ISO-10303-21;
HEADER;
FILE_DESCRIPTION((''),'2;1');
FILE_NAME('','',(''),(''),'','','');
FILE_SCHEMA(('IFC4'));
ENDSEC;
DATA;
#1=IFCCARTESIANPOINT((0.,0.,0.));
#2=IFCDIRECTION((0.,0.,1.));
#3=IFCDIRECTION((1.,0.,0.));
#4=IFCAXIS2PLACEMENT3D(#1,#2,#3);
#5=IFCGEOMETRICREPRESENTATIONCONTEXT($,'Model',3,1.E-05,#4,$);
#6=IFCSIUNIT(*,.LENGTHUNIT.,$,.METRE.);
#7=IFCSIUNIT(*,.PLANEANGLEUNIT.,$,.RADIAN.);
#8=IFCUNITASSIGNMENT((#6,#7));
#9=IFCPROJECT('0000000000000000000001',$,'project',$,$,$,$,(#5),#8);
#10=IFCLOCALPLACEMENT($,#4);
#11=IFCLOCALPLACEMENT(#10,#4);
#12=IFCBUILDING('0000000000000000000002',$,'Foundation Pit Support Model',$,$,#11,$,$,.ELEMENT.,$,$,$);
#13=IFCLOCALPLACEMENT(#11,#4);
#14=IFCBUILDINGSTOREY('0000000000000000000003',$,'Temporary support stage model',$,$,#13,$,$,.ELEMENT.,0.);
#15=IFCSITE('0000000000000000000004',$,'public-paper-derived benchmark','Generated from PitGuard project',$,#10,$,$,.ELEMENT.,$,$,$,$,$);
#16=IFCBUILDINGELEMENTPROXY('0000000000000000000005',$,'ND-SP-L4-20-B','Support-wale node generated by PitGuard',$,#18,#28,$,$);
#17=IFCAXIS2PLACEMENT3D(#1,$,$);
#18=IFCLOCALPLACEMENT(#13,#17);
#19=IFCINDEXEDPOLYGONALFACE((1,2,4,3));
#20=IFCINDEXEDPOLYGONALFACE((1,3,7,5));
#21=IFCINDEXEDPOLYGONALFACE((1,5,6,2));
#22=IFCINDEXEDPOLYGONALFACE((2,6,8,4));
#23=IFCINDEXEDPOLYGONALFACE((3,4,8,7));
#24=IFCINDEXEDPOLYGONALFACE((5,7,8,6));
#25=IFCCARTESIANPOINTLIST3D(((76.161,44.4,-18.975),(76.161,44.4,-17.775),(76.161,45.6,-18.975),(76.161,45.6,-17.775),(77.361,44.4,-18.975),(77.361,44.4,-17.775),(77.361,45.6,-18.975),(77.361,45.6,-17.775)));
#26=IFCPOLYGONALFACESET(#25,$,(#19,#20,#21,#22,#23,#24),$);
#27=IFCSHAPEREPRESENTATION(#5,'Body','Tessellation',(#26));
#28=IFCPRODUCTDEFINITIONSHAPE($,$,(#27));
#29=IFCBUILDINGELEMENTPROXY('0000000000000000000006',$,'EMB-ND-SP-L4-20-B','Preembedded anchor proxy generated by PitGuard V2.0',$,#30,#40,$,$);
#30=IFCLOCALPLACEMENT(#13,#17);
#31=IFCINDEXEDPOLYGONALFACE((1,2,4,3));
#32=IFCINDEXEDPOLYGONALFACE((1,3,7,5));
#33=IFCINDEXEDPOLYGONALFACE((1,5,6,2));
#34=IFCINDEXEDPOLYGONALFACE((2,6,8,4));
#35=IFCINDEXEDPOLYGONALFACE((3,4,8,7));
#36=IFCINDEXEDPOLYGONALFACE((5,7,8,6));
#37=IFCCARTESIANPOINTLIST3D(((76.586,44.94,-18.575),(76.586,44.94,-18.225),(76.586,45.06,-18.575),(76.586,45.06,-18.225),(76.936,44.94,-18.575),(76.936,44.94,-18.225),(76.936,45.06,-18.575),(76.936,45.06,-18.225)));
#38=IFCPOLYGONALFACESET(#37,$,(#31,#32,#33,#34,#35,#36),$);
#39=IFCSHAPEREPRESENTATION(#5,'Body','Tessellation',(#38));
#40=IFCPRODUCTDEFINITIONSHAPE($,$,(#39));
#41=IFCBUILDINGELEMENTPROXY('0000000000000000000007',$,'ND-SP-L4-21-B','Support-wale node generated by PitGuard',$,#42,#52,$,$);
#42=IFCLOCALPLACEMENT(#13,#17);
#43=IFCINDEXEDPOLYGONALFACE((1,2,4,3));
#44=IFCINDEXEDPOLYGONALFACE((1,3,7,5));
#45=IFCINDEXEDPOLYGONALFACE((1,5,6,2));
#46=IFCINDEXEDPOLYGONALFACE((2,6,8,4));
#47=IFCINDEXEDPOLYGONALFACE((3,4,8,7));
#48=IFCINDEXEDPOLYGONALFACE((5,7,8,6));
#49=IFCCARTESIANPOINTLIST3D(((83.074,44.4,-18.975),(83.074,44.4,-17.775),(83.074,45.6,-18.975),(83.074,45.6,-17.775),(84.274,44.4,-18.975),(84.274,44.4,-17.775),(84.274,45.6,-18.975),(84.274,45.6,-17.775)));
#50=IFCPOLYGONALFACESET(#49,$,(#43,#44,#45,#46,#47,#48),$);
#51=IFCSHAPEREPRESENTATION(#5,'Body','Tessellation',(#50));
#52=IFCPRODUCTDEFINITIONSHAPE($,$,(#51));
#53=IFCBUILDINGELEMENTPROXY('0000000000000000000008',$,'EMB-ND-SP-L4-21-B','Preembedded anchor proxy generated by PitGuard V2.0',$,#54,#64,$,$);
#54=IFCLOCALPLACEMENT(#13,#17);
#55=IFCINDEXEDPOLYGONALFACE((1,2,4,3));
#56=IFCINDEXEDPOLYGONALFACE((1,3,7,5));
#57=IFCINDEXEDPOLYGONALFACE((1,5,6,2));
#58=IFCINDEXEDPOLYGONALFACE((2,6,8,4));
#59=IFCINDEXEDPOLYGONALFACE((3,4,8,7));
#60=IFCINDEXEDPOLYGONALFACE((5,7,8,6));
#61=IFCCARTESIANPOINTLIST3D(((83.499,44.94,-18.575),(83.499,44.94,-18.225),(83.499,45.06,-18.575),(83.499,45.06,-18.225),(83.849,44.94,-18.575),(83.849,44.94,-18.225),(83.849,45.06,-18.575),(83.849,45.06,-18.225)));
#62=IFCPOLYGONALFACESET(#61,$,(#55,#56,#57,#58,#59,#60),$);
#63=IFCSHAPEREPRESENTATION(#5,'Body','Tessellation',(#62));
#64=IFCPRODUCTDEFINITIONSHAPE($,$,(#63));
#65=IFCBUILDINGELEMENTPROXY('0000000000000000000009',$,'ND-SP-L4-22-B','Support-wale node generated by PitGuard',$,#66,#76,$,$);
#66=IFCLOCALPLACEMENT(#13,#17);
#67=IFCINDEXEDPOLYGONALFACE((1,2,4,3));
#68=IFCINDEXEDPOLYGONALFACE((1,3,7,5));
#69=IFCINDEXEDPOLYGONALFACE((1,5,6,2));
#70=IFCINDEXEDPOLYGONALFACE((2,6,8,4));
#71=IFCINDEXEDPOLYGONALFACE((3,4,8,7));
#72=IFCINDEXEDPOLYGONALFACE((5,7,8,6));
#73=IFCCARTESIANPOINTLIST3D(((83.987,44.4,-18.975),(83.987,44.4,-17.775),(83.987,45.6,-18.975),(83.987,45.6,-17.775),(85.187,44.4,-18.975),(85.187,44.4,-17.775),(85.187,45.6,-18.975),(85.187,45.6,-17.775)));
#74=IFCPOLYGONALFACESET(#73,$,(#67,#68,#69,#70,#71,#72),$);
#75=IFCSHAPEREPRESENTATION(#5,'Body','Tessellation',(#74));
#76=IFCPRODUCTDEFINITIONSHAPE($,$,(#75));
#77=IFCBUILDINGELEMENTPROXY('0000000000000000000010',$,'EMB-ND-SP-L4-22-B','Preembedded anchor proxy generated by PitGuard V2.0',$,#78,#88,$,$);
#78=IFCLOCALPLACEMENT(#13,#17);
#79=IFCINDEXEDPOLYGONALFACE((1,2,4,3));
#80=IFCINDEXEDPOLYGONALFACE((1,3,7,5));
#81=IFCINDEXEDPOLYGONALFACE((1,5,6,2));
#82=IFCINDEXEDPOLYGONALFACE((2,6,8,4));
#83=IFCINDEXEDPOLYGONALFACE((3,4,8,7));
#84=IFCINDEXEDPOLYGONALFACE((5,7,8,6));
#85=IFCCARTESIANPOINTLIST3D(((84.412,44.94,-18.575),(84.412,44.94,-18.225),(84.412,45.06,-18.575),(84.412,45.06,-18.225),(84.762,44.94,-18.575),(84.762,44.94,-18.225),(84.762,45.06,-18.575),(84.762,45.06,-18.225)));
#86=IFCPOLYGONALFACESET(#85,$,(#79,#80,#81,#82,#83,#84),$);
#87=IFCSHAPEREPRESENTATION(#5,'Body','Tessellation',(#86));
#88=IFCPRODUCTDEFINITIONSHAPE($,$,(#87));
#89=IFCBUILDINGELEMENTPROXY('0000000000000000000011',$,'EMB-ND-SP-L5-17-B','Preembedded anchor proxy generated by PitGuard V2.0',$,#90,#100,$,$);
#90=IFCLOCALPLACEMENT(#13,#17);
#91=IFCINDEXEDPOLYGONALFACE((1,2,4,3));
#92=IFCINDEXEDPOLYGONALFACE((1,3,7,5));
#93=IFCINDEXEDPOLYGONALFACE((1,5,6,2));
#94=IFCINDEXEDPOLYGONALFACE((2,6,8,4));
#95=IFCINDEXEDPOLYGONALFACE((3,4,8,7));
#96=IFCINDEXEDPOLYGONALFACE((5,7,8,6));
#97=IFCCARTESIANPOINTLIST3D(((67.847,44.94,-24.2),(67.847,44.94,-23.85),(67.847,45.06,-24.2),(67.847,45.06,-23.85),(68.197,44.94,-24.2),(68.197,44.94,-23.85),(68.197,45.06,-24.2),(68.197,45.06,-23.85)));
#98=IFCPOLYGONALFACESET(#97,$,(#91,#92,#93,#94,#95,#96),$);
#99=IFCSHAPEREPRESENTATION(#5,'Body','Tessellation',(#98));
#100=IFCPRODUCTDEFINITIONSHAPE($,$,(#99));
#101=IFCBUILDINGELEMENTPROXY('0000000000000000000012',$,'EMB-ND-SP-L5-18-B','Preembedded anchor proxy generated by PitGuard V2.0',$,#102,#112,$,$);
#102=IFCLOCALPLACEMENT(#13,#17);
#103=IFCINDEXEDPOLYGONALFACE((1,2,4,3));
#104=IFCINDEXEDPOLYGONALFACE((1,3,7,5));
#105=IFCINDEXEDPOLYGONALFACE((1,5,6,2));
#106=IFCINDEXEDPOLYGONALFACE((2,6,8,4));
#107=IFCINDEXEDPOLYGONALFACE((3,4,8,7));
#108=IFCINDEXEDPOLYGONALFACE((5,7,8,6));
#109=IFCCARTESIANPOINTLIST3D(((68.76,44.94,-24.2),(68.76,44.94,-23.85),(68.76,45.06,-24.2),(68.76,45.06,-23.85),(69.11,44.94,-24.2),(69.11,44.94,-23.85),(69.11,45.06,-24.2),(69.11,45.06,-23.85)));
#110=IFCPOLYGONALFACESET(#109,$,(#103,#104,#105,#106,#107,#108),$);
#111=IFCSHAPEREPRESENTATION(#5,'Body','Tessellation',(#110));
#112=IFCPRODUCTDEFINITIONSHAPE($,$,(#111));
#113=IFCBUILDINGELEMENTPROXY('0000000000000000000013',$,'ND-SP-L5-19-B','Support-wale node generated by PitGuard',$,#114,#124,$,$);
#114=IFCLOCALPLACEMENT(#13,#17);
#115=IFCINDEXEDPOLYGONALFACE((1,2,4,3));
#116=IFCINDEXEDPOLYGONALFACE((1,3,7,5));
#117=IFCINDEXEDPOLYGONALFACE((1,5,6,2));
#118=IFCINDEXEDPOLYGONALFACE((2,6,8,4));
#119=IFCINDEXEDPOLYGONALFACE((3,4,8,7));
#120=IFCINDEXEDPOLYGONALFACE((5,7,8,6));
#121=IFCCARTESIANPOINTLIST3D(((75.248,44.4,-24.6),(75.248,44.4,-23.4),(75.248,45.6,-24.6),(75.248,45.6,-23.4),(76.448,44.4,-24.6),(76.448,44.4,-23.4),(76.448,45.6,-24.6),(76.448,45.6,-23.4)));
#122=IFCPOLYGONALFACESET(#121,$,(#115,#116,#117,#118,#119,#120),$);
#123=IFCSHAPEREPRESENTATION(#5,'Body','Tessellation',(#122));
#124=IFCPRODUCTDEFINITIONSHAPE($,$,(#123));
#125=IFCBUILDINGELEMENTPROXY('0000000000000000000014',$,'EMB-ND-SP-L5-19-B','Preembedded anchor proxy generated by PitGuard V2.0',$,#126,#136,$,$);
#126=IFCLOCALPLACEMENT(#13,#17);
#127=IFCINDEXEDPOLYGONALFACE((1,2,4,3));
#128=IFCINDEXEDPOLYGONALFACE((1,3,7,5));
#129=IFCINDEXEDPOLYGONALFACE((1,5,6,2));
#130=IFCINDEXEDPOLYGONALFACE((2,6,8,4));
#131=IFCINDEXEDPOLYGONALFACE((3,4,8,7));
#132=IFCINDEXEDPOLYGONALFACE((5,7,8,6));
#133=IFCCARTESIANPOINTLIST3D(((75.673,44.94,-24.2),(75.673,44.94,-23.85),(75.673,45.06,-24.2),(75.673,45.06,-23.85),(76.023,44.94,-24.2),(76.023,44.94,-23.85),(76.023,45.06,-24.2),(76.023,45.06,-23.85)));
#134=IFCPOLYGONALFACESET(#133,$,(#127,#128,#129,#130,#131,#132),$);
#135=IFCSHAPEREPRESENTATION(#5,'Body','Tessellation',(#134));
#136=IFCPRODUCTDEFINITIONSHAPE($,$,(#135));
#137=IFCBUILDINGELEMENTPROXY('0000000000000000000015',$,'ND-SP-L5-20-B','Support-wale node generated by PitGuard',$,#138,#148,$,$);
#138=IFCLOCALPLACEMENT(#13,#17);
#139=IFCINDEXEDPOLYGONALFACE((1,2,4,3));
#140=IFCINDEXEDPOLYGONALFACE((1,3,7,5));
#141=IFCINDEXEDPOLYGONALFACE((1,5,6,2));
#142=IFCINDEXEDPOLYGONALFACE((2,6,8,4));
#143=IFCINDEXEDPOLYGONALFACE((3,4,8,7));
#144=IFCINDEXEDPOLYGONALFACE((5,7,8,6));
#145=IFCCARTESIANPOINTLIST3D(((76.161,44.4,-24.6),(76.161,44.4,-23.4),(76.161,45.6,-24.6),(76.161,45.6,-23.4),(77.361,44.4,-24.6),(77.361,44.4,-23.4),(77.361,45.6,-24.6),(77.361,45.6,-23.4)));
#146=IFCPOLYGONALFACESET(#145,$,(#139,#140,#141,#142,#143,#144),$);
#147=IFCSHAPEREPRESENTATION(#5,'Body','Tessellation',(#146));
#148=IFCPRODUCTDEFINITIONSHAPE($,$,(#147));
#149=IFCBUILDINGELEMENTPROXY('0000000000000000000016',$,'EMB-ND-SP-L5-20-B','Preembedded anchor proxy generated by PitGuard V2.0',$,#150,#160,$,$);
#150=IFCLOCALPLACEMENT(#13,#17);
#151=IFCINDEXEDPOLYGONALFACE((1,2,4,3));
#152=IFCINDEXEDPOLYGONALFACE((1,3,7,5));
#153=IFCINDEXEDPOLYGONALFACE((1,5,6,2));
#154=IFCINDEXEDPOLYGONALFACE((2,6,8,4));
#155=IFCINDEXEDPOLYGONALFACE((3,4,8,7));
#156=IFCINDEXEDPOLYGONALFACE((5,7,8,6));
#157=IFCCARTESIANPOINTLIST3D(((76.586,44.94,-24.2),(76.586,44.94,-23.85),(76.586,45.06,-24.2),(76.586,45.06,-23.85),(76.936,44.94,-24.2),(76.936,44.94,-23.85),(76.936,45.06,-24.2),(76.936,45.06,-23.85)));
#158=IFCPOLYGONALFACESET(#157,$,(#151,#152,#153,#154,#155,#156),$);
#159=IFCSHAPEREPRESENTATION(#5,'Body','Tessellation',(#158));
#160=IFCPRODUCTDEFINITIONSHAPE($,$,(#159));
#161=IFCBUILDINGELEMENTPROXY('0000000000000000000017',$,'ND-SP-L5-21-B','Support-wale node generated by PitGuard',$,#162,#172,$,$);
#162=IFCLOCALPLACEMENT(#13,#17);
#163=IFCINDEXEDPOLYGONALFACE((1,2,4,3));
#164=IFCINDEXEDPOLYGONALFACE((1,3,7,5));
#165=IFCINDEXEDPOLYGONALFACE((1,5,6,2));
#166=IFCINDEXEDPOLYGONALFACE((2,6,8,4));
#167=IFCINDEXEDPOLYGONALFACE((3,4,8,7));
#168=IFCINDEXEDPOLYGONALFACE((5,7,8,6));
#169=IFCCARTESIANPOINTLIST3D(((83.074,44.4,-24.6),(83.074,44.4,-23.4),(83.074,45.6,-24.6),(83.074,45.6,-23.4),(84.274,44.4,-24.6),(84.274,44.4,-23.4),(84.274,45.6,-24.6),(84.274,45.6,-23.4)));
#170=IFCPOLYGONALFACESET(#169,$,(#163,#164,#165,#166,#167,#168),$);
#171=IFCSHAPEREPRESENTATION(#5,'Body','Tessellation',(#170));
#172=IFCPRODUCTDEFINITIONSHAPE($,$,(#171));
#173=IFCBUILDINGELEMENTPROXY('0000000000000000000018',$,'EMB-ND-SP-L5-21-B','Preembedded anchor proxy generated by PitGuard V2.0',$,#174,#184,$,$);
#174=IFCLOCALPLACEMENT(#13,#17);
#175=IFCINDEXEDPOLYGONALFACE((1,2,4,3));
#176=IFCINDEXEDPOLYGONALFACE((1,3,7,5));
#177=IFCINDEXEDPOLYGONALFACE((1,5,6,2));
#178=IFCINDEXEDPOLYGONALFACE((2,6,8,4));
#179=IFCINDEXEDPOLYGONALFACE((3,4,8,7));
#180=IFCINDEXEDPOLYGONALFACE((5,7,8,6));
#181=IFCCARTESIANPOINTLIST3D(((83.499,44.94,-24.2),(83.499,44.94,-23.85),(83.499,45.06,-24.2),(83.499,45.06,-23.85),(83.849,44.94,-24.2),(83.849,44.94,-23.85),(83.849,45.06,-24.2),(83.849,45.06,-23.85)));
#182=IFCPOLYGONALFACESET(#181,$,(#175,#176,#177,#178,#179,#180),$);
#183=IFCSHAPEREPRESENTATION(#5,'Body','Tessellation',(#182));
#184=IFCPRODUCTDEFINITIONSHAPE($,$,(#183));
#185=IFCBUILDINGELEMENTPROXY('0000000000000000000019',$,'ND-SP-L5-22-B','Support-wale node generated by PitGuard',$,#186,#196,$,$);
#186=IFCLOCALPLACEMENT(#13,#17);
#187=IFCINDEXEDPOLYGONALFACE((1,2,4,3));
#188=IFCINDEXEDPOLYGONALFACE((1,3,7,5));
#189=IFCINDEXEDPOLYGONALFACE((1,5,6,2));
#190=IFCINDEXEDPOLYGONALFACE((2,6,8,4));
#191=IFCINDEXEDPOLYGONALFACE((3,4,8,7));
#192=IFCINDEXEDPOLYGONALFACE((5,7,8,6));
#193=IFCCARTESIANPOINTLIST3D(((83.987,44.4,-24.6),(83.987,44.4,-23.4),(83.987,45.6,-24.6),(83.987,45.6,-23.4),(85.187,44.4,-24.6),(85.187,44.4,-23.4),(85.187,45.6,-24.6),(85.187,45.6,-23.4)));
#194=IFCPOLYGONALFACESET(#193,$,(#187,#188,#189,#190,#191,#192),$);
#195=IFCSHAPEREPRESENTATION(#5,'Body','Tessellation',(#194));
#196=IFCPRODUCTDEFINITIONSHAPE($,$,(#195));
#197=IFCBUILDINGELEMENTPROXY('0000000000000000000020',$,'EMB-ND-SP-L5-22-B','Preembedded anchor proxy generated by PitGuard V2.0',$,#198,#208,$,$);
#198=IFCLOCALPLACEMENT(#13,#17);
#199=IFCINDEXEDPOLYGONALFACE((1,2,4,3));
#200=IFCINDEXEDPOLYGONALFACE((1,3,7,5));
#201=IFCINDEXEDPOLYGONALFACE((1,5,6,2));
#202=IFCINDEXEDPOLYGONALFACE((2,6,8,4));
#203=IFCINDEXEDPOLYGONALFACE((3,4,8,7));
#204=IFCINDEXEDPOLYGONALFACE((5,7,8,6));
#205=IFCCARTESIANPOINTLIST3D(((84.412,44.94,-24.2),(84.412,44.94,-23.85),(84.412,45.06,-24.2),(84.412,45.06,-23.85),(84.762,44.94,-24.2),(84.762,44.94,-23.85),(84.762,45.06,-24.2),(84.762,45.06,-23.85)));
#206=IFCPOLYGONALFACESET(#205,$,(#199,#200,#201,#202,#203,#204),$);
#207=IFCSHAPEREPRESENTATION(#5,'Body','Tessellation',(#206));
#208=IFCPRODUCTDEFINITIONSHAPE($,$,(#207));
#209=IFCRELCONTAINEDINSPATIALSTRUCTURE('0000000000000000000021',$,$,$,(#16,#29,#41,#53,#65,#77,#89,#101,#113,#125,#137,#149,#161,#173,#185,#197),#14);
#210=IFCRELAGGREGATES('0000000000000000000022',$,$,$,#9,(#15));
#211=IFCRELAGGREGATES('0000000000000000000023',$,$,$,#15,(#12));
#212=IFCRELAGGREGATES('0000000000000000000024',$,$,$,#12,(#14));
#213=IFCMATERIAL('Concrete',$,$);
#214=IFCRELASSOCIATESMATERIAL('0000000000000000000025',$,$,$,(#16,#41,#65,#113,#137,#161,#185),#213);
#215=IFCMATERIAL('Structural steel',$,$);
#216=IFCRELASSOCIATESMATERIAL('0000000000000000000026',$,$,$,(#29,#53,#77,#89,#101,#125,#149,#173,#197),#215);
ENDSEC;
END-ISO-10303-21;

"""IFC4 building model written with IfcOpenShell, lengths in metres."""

from ifc_helpers import new_model, si_unit, frame, origin_with_axes, origin_2d, place, context, project, spatial, rectangle, extrude, material, element, save


model = new_model("IFC4")

# Units and contexts
model_context = context("Model", 3, precision=1e-05, world=origin_with_axes())
ifc_project = project(units=[si_unit("LENGTHUNIT", "METRE"), si_unit("PLANEANGLEUNIT", "RADIAN")], contexts=[model_context])

# Site, building, storey
site_placement = place(None, origin_with_axes())
site = spatial("IfcSite", under=ifc_project, at=site_placement, Name="public-paper-derived benchmark", Description="Generated from PitGuard project", CompositionType="ELEMENT")
building_placement = place(site_placement, origin_with_axes())
building = spatial("IfcBuilding", under=site, at=building_placement, Name="Foundation Pit Support Model", CompositionType="ELEMENT")
storey_placement = place(building_placement, origin_with_axes())
storey = spatial("IfcBuildingStorey", under=building, at=storey_placement, Name="Temporary support stage model", CompositionType="ELEMENT", Elevation=0.0)

# Shared definitions
ifc_material_1 = material(Name="Structural steel")

# Building element proxies
ifc_material_2 = material(Name="Concrete")
proxy_1_placement = place(storey_placement, frame((76.761, 45.0, -18.975), z_axis=(0.0, 0.0, 1.0), x_axis=(1.0, 0.0, 0.0)))
element("IfcBuildingElementProxy", 1, at=proxy_1_placement, inside=storey, material=ifc_material_2, Name="ND-SP-L4-20-B", Description="Support-wale node generated by PitGuard", context=model_context, shape_type="SweptSolid", body=[
    extrude(rectangle(XDim=1.2, YDim=1.2, at=origin_2d()), origin_with_axes(), (0.0, 0.0, 1.0), 1.2),
])
proxy_2_placement = place(storey_placement, frame((76.761, 45.0, -18.575), z_axis=(0.0, 0.0, 1.0), x_axis=(1.0, 0.0, 0.0)))
element("IfcBuildingElementProxy", 2, at=proxy_2_placement, inside=storey, material=ifc_material_1, Name="EMB-ND-SP-L4-20-B", Description="Preembedded anchor proxy generated by PitGuard V2.0", context=model_context, shape_type="SweptSolid", body=[
    extrude(rectangle(XDim=0.35, YDim=0.12, at=origin_2d()), origin_with_axes(), (0.0, 0.0, 1.0), 0.35),
])
proxy_3_placement = place(storey_placement, frame((83.674, 45.0, -18.975), z_axis=(0.0, 0.0, 1.0), x_axis=(1.0, 0.0, 0.0)))
element("IfcBuildingElementProxy", 3, at=proxy_3_placement, inside=storey, material=ifc_material_2, Name="ND-SP-L4-21-B", Description="Support-wale node generated by PitGuard", context=model_context, shape_type="SweptSolid", body=[
    extrude(rectangle(XDim=1.2, YDim=1.2, at=origin_2d()), origin_with_axes(), (0.0, 0.0, 1.0), 1.2),
])
proxy_4_placement = place(storey_placement, frame((83.674, 45.0, -18.575), z_axis=(0.0, 0.0, 1.0), x_axis=(1.0, 0.0, 0.0)))
element("IfcBuildingElementProxy", 4, at=proxy_4_placement, inside=storey, material=ifc_material_1, Name="EMB-ND-SP-L4-21-B", Description="Preembedded anchor proxy generated by PitGuard V2.0", context=model_context, shape_type="SweptSolid", body=[
    extrude(rectangle(XDim=0.35, YDim=0.12, at=origin_2d()), origin_with_axes(), (0.0, 0.0, 1.0), 0.35),
])
proxy_5_placement = place(storey_placement, frame((84.587, 45.0, -18.975), z_axis=(0.0, 0.0, 1.0), x_axis=(1.0, 0.0, 0.0)))
element("IfcBuildingElementProxy", 5, at=proxy_5_placement, inside=storey, material=ifc_material_2, Name="ND-SP-L4-22-B", Description="Support-wale node generated by PitGuard", context=model_context, shape_type="SweptSolid", body=[
    extrude(rectangle(XDim=1.2, YDim=1.2, at=origin_2d()), origin_with_axes(), (0.0, 0.0, 1.0), 1.2),
])
for number, where, z_axis, x_axis, name in (
    (6, (84.587, 45.0, -18.575), (0.0, 0.0, 1.0), (1.0, 0.0, 0.0), "EMB-ND-SP-L4-22-B"),
    (7, (68.022, 45.0, -24.2), (0.0, 0.0, 1.0), (1.0, 0.0, 0.0), "EMB-ND-SP-L5-17-B"),
    (8, (68.935, 45.0, -24.2), (0.0, 0.0, 1.0), (1.0, 0.0, 0.0), "EMB-ND-SP-L5-18-B"),
):
    element("IfcBuildingElementProxy", number, at=place(storey_placement, frame(where, z_axis=z_axis, x_axis=x_axis)), inside=storey, material=ifc_material_1, Name=name, Description="Preembedded anchor proxy generated by PitGuard V2.0", context=model_context, shape_type="SweptSolid", body=[
        extrude(rectangle(XDim=0.35, YDim=0.12, at=origin_2d()), origin_with_axes(), (0.0, 0.0, 1.0), 0.35),
    ])
proxy_6_placement = place(storey_placement, frame((75.848, 45.0, -24.6), z_axis=(0.0, 0.0, 1.0), x_axis=(1.0, 0.0, 0.0)))
element("IfcBuildingElementProxy", 9, at=proxy_6_placement, inside=storey, material=ifc_material_2, Name="ND-SP-L5-19-B", Description="Support-wale node generated by PitGuard", context=model_context, shape_type="SweptSolid", body=[
    extrude(rectangle(XDim=1.2, YDim=1.2, at=origin_2d()), origin_with_axes(), (0.0, 0.0, 1.0), 1.2),
])
proxy_7_placement = place(storey_placement, frame((75.848, 45.0, -24.2), z_axis=(0.0, 0.0, 1.0), x_axis=(1.0, 0.0, 0.0)))
element("IfcBuildingElementProxy", 10, at=proxy_7_placement, inside=storey, material=ifc_material_1, Name="EMB-ND-SP-L5-19-B", Description="Preembedded anchor proxy generated by PitGuard V2.0", context=model_context, shape_type="SweptSolid", body=[
    extrude(rectangle(XDim=0.35, YDim=0.12, at=origin_2d()), origin_with_axes(), (0.0, 0.0, 1.0), 0.35),
])
proxy_8_placement = place(storey_placement, frame((76.761, 45.0, -24.6), z_axis=(0.0, 0.0, 1.0), x_axis=(1.0, 0.0, 0.0)))
element("IfcBuildingElementProxy", 11, at=proxy_8_placement, inside=storey, material=ifc_material_2, Name="ND-SP-L5-20-B", Description="Support-wale node generated by PitGuard", context=model_context, shape_type="SweptSolid", body=[
    extrude(rectangle(XDim=1.2, YDim=1.2, at=origin_2d()), origin_with_axes(), (0.0, 0.0, 1.0), 1.2),
])
proxy_9_placement = place(storey_placement, frame((76.761, 45.0, -24.2), z_axis=(0.0, 0.0, 1.0), x_axis=(1.0, 0.0, 0.0)))
element("IfcBuildingElementProxy", 12, at=proxy_9_placement, inside=storey, material=ifc_material_1, Name="EMB-ND-SP-L5-20-B", Description="Preembedded anchor proxy generated by PitGuard V2.0", context=model_context, shape_type="SweptSolid", body=[
    extrude(rectangle(XDim=0.35, YDim=0.12, at=origin_2d()), origin_with_axes(), (0.0, 0.0, 1.0), 0.35),
])
proxy_10_placement = place(storey_placement, frame((83.674, 45.0, -24.6), z_axis=(0.0, 0.0, 1.0), x_axis=(1.0, 0.0, 0.0)))
element("IfcBuildingElementProxy", 13, at=proxy_10_placement, inside=storey, material=ifc_material_2, Name="ND-SP-L5-21-B", Description="Support-wale node generated by PitGuard", context=model_context, shape_type="SweptSolid", body=[
    extrude(rectangle(XDim=1.2, YDim=1.2, at=origin_2d()), origin_with_axes(), (0.0, 0.0, 1.0), 1.2),
])
proxy_11_placement = place(storey_placement, frame((83.674, 45.0, -24.2), z_axis=(0.0, 0.0, 1.0), x_axis=(1.0, 0.0, 0.0)))
element("IfcBuildingElementProxy", 14, at=proxy_11_placement, inside=storey, material=ifc_material_1, Name="EMB-ND-SP-L5-21-B", Description="Preembedded anchor proxy generated by PitGuard V2.0", context=model_context, shape_type="SweptSolid", body=[
    extrude(rectangle(XDim=0.35, YDim=0.12, at=origin_2d()), origin_with_axes(), (0.0, 0.0, 1.0), 0.35),
])
proxy_12_placement = place(storey_placement, frame((84.587, 45.0, -24.6), z_axis=(0.0, 0.0, 1.0), x_axis=(1.0, 0.0, 0.0)))
element("IfcBuildingElementProxy", 15, at=proxy_12_placement, inside=storey, material=ifc_material_2, Name="ND-SP-L5-22-B", Description="Support-wale node generated by PitGuard", context=model_context, shape_type="SweptSolid", body=[
    extrude(rectangle(XDim=1.2, YDim=1.2, at=origin_2d()), origin_with_axes(), (0.0, 0.0, 1.0), 1.2),
])
proxy_13_placement = place(storey_placement, frame((84.587, 45.0, -24.2), z_axis=(0.0, 0.0, 1.0), x_axis=(1.0, 0.0, 0.0)))
element("IfcBuildingElementProxy", 16, at=proxy_13_placement, inside=storey, material=ifc_material_1, Name="EMB-ND-SP-L5-22-B", Description="Preembedded anchor proxy generated by PitGuard V2.0", context=model_context, shape_type="SweptSolid", body=[
    extrude(rectangle(XDim=0.35, YDim=0.12, at=origin_2d()), origin_with_axes(), (0.0, 0.0, 1.0), 0.35),
])

save(model, "model.ifc")
